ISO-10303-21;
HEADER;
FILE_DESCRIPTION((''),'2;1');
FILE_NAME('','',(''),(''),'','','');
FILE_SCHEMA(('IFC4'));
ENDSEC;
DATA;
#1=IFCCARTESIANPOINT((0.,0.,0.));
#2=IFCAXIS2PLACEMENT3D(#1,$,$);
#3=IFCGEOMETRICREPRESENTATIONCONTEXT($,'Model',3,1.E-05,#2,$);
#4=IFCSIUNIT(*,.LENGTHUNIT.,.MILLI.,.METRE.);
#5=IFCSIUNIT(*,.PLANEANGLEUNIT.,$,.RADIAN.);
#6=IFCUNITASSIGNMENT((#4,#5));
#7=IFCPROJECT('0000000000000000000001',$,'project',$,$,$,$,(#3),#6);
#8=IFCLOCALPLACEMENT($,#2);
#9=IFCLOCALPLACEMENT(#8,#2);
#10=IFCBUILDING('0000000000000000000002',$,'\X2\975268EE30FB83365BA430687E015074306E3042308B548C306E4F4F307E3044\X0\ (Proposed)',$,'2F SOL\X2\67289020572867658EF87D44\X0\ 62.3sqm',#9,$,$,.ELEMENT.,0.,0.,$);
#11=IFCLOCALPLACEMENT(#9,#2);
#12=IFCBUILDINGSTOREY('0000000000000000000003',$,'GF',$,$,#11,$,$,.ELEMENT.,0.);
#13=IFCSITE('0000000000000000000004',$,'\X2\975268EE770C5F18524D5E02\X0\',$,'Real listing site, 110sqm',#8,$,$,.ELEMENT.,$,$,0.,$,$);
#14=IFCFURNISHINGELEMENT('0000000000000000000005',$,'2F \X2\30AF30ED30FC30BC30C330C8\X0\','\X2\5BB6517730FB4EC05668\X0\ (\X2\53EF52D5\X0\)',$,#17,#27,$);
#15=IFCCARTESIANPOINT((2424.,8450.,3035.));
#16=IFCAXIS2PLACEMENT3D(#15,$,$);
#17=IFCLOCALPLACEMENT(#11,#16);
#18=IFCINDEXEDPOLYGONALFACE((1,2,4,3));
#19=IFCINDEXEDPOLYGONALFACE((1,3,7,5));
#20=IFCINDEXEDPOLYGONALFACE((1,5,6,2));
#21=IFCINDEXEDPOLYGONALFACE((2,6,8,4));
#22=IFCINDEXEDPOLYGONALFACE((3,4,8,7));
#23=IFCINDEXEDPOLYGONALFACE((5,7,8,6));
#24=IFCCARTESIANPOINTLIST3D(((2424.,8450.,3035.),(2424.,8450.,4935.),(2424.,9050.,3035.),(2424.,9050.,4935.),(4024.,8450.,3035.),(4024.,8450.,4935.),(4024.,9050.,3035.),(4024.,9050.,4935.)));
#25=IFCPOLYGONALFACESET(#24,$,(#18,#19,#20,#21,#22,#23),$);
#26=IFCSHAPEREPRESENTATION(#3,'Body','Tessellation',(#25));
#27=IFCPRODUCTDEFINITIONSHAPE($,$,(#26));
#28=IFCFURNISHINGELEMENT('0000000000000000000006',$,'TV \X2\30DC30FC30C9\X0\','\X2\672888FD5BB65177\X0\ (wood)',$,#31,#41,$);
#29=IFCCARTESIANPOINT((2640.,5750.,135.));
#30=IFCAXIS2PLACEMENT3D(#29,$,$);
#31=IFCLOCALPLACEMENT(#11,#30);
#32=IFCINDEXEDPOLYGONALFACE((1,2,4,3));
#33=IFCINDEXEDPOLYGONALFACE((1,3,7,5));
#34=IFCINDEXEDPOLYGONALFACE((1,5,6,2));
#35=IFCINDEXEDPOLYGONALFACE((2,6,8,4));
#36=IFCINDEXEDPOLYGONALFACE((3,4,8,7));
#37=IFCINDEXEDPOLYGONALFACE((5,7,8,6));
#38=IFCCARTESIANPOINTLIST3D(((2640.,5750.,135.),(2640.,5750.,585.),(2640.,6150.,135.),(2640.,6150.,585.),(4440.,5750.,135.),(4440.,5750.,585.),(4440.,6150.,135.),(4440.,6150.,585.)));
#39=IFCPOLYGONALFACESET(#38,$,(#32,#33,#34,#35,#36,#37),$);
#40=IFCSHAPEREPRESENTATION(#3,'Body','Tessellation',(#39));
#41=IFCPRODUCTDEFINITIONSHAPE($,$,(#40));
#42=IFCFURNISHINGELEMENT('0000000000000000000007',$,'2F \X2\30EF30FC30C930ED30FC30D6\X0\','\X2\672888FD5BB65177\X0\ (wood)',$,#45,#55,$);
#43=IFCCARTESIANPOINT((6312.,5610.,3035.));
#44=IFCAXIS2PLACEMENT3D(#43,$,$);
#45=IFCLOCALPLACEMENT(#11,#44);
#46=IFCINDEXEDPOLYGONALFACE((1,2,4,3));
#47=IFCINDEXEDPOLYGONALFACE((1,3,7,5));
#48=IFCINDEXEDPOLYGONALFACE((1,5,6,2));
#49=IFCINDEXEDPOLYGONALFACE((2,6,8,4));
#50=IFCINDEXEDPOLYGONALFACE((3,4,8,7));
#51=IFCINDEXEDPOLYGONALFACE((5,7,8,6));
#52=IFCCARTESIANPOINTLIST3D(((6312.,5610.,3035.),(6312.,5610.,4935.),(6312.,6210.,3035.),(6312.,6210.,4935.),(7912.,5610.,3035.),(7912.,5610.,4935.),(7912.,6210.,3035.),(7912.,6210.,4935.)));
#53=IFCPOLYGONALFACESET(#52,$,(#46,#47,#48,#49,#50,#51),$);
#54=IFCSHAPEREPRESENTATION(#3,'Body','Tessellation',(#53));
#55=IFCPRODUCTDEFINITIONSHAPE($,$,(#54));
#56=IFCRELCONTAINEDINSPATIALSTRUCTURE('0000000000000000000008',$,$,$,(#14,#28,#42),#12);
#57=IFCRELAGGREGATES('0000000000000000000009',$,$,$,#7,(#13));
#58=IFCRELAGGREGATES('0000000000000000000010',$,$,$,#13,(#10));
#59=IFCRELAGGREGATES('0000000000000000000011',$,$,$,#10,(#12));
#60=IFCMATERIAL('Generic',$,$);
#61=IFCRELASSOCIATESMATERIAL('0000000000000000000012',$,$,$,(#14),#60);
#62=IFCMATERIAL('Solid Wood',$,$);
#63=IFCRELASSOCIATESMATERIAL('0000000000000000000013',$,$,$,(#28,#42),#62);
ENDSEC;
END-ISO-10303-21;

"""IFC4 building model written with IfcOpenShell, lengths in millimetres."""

from ifc_helpers import new_model, si_unit, frame, frame_2d, origin, place, context, project, spatial, rectangle, extrude, material, element, save


model = new_model("IFC4")

# Units and contexts
model_context = context("Model", 3, precision=1e-05, world=origin())
ifc_project = project(units=[si_unit("LENGTHUNIT", "METRE", prefix="MILLI"), si_unit("PLANEANGLEUNIT", "RADIAN")], contexts=[model_context])

# Site, building, storey
site_placement = place(None, origin())
site = spatial("IfcSite", under=ifc_project, at=site_placement, Name="青森県弘前市", ObjectType="Real listing site, 110sqm", CompositionType="ELEMENT", RefElevation=0.0)
building_placement = place(site_placement, origin())
building = spatial("IfcBuilding", under=site, at=building_placement, Name="青森・茶室と縁側のある和の住まい (Proposed)", ObjectType="2F SOL木造在来軸組 62.3sqm", CompositionType="ELEMENT", ElevationOfRefHeight=0.0, ElevationOfTerrain=0.0)
storey_placement = place(building_placement, origin())
storey = spatial("IfcBuildingStorey", under=building, at=storey_placement, Name="GF", CompositionType="ELEMENT", Elevation=0.0)

# Shared definitions
ifc_material_1 = material(Name="Solid Wood")

# Shared definitions
ifc_material_2 = material(Name="Generic")

# Furnishing elements
furnishing_1_placement = place(storey_placement, frame((2424.0, 8450.0, 3035.0)))
element("IfcFurnishingElement", 1, at=furnishing_1_placement, inside=storey, material=ifc_material_2, Name="2F クローゼット", Description="家具・什器 (可動)", context=model_context, shape_type="SweptSolid", body=[
    extrude(rectangle(XDim=1600.0, YDim=600.0, at=frame_2d((800.0, 300.0))), frame((2424.0, 8450.0, 3035.0)), (0.0, 0.0, 1.0), 1900.0),
])
furnishing_2_placement = place(storey_placement, frame((2640.0, 5750.0, 135.0)))
element("IfcFurnishingElement", 2, at=furnishing_2_placement, inside=storey, material=ifc_material_1, Name="TV ボード", Description="木製家具 (wood)", context=model_context, shape_type="SweptSolid", body=[
    extrude(rectangle(XDim=1800.0, YDim=400.0, at=frame_2d((900.0, 200.0))), frame((2640.0, 5750.0, 135.0)), (0.0, 0.0, 1.0), 450.0),
])
furnishing_3_placement = place(storey_placement, frame((6312.0, 5610.0, 3035.0)))
element("IfcFurnishingElement", 3, at=furnishing_3_placement, inside=storey, material=ifc_material_1, Name="2F ワードローブ", Description="木製家具 (wood)", context=model_context, shape_type="SweptSolid", body=[
    extrude(rectangle(XDim=1600.0, YDim=600.0, at=frame_2d((800.0, 300.0))), frame((6312.0, 5610.0, 3035.0)), (0.0, 0.0, 1.0), 1900.0),
])

save(model, "model.ifc")
